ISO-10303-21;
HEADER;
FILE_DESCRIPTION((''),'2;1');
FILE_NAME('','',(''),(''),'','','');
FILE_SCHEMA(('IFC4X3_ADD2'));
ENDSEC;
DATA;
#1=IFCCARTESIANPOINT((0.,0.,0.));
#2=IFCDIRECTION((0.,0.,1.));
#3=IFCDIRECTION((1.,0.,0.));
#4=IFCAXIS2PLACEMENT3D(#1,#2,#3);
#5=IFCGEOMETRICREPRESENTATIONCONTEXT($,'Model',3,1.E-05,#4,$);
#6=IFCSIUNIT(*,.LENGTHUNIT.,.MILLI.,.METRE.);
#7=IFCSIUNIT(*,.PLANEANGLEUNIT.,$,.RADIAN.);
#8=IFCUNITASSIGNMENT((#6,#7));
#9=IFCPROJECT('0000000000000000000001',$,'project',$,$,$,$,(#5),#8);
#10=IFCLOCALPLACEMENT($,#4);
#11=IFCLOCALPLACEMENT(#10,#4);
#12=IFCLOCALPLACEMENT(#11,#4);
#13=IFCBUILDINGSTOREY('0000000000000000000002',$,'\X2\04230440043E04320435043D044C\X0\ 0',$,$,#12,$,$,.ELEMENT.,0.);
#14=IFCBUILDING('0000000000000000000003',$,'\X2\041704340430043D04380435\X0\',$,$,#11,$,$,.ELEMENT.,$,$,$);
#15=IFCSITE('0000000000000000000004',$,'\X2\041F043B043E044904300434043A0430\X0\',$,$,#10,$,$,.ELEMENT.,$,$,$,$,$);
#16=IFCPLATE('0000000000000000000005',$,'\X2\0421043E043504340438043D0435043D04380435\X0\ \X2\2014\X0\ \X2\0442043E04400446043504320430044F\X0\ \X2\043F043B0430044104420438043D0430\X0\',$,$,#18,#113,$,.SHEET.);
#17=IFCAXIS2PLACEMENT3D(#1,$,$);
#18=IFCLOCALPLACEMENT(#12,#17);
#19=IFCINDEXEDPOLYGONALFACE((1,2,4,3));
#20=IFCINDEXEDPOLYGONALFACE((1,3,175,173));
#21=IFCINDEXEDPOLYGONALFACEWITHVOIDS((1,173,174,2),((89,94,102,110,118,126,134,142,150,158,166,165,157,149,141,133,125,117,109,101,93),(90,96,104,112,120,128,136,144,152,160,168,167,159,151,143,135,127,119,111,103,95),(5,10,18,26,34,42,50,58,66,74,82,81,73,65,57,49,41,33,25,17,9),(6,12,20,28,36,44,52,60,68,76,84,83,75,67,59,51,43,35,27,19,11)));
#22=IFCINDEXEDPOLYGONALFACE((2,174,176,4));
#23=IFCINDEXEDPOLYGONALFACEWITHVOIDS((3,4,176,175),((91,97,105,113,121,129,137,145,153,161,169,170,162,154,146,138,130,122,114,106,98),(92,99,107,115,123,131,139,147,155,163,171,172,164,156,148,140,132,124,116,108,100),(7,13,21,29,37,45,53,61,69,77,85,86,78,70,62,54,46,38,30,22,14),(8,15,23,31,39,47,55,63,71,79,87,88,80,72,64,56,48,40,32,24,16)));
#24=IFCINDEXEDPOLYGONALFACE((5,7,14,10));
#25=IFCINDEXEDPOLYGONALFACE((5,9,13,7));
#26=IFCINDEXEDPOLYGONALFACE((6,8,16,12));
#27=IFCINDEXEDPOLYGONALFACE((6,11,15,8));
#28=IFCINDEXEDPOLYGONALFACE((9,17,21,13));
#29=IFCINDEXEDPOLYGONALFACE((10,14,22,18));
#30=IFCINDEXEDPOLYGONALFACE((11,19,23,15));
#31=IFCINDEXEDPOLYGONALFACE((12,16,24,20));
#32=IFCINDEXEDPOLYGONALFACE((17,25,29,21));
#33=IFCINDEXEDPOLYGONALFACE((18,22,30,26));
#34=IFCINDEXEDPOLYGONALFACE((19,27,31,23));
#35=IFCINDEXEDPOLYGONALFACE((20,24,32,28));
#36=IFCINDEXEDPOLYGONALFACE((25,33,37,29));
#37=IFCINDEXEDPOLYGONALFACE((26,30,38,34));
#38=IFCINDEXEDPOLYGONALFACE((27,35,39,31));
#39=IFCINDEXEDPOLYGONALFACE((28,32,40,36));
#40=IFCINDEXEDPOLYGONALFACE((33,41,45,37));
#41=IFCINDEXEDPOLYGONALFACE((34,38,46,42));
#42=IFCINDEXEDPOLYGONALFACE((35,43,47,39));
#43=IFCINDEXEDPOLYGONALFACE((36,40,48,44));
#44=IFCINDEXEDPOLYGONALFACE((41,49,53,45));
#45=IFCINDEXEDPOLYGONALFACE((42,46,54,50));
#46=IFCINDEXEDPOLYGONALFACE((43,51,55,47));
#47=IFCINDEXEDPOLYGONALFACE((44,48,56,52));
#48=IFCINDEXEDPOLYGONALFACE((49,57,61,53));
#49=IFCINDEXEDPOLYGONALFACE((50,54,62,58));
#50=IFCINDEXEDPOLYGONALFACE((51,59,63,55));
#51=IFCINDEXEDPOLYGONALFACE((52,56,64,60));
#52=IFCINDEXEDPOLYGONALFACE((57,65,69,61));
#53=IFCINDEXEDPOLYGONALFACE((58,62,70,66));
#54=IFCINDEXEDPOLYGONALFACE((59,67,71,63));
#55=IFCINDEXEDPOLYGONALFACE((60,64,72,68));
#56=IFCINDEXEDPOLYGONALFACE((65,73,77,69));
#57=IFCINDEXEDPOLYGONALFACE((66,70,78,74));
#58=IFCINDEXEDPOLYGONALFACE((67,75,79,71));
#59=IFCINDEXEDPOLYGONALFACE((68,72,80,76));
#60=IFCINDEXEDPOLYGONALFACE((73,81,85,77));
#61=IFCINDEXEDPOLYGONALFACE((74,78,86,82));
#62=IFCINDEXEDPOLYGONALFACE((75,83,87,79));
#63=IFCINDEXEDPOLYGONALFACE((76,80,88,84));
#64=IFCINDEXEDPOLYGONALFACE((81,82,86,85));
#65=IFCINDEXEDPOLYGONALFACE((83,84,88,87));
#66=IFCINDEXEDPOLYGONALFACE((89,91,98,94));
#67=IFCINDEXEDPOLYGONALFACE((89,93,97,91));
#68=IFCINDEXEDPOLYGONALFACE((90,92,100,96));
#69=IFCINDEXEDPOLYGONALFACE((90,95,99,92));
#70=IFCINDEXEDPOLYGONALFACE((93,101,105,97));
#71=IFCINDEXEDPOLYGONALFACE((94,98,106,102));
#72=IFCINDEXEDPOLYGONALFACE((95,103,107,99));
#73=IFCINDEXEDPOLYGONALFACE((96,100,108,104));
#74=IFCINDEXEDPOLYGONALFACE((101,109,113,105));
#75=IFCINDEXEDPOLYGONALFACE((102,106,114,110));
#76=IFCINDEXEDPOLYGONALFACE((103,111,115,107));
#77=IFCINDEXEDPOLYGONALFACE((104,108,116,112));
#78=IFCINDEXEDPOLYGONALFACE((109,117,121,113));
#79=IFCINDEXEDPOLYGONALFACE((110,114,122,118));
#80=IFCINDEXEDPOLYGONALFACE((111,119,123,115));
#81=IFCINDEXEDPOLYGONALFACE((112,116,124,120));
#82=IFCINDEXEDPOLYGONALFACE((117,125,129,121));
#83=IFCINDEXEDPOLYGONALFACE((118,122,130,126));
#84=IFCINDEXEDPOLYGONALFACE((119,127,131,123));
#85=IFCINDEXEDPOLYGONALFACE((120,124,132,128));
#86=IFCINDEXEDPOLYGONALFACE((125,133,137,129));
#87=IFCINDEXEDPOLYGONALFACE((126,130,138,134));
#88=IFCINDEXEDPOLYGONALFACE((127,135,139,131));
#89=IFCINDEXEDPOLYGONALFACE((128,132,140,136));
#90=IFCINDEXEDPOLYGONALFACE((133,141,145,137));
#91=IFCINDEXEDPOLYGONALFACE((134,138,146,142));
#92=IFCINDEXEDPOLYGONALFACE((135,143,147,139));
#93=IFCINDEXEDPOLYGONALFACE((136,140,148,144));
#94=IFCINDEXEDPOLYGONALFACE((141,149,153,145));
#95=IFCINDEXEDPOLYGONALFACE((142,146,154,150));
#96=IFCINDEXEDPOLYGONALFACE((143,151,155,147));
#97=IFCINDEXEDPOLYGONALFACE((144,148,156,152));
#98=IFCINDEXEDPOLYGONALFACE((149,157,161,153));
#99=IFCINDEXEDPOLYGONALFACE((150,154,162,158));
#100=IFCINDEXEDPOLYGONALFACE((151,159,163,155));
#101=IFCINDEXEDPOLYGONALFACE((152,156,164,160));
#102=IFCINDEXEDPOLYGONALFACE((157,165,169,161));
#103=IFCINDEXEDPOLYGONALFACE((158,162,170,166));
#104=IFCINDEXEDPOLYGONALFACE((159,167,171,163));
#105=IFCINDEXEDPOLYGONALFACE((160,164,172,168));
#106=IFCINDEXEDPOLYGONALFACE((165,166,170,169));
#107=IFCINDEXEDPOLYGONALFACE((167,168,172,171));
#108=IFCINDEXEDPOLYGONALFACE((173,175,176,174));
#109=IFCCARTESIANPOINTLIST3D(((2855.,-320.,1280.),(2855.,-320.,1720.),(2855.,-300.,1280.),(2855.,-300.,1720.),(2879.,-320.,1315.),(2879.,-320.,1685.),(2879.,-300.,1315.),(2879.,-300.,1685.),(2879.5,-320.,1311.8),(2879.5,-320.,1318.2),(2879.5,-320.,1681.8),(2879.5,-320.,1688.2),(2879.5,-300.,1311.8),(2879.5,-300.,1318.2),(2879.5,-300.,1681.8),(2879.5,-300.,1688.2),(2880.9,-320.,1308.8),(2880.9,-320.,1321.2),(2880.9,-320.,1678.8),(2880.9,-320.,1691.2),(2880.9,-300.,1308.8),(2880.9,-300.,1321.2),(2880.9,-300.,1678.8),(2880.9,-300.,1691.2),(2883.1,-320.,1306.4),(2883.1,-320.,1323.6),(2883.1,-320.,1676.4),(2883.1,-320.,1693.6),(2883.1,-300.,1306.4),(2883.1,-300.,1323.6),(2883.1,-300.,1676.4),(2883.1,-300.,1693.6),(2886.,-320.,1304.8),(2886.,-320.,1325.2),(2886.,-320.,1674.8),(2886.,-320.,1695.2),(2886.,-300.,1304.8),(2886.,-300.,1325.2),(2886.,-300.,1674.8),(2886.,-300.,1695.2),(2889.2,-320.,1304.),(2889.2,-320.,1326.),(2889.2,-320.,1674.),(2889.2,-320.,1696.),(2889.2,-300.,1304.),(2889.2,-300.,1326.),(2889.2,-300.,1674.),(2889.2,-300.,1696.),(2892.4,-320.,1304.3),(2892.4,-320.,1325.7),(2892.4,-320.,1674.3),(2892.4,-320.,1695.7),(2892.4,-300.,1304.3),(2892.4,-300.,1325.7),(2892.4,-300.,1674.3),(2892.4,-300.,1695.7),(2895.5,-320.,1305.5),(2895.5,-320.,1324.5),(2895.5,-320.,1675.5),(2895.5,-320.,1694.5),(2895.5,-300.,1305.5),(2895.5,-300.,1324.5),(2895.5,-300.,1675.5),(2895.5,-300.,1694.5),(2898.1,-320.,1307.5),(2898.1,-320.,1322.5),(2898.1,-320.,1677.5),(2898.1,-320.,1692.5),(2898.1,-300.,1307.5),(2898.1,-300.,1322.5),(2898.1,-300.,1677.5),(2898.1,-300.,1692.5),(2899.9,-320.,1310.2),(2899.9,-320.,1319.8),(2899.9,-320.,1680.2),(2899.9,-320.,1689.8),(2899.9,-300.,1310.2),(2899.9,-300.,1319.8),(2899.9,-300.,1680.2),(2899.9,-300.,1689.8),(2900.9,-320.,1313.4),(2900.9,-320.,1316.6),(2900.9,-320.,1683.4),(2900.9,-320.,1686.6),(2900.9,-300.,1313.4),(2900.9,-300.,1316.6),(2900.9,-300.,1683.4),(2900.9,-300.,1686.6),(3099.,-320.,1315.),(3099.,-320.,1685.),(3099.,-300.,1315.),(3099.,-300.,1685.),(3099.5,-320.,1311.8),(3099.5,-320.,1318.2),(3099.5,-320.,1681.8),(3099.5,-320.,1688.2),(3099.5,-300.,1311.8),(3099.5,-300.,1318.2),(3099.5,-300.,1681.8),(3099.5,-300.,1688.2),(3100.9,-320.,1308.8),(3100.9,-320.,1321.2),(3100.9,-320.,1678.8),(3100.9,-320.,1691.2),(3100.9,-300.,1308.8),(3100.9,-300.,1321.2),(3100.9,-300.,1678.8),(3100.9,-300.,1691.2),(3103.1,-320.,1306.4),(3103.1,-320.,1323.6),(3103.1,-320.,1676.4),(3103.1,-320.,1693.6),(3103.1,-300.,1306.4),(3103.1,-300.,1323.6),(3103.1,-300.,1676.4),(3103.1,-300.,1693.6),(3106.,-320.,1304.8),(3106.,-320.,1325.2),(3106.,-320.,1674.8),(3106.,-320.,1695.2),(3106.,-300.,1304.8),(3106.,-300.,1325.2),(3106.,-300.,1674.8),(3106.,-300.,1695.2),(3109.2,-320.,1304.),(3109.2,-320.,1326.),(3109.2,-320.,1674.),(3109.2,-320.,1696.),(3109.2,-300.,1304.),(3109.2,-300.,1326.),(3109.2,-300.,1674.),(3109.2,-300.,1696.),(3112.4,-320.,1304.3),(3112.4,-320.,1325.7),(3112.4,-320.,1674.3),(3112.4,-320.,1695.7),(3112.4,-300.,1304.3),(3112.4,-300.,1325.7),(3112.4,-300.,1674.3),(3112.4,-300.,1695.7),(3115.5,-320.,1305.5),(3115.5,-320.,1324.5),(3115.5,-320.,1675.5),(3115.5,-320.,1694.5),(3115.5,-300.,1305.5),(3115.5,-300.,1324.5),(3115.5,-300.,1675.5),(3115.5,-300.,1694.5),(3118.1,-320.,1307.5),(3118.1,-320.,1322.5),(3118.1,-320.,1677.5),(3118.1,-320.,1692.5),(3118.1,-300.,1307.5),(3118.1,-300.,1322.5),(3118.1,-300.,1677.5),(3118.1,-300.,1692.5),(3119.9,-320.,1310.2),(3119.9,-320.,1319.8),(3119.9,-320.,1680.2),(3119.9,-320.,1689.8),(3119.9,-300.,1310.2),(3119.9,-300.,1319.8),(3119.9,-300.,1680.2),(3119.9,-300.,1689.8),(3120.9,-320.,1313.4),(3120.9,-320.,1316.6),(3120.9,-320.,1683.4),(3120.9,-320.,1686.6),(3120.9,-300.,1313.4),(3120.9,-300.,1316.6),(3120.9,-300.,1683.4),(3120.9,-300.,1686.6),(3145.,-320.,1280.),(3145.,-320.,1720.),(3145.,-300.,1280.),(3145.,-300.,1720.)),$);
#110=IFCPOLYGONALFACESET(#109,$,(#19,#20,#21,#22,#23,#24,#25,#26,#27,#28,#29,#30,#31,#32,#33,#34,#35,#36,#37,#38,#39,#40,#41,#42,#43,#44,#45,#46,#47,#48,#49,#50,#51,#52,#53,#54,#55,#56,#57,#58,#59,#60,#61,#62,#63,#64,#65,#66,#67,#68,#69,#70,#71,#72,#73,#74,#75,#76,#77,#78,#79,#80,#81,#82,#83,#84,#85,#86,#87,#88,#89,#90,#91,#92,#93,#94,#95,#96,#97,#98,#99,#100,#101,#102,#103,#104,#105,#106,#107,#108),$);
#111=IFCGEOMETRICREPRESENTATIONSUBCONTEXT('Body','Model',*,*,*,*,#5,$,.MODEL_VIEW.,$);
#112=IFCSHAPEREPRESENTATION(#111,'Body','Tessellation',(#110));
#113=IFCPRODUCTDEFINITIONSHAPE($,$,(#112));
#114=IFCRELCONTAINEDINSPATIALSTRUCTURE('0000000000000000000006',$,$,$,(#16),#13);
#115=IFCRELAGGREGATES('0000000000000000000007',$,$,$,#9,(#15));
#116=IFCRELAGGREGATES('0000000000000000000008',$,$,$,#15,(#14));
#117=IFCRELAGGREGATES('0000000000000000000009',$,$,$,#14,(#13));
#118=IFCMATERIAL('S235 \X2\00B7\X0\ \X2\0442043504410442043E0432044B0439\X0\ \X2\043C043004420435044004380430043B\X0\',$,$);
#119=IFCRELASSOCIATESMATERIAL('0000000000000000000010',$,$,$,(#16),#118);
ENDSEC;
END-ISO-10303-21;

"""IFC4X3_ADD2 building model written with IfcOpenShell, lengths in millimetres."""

from ifc_helpers import new_model, si_unit, frame, origin_with_axes, place, context, subcontext, project, spatial, polyline, circle, outline, extrude, material, element, save


model = new_model("IFC4X3_ADD2")

# Units and contexts
model_context = context("Model", 3, precision=1e-05, world=origin_with_axes())
body_context = subcontext(model_context, "Body", "Model", "MODEL_VIEW")
ifc_project = project(units=[si_unit("LENGTHUNIT", "METRE", prefix="MILLI"), si_unit("PLANEANGLEUNIT", "RADIAN")], contexts=[model_context])

# Site, building, storey
site_placement = place(None, origin_with_axes())
site = spatial("IfcSite", under=ifc_project, at=site_placement, Name="Площадка", CompositionType="ELEMENT")
building_placement = place(site_placement, origin_with_axes())
building = spatial("IfcBuilding", under=site, at=building_placement, Name="Здание", CompositionType="ELEMENT")
storey_placement = place(building_placement, origin_with_axes())
storey = spatial("IfcBuildingStorey", under=building, at=storey_placement, Name="Уровень 0", CompositionType="ELEMENT", Elevation=0.0)

# Shared definitions
ifc_material = material(Name="S235 · тестовый материал")

# Plate, openings
plate_1_placement = place(storey_placement, frame((3145.0, -320.0, 1280.0), z_axis=(0.0, 1.0, 0.0), x_axis=(-1.0, 0.0, 0.0)))
plate_1 = element("IfcPlate", 1, at=plate_1_placement, inside=storey, material=ifc_material, Name="Соединение — торцевая пластина", PredefinedType="SHEET", context=body_context, shape_type="SweptSolid", body=[
    extrude(outline(polyline([(0.0, 0.0), (290.0, 0.0), (290.0, 440.0), (0.0, 440.0), (0.0, 0.0)])), origin_with_axes(), (0.0, 0.0, 1.0), 20.0),
])
opening_1_placement = place(plate_1_placement, frame((35.0, 35.0, -1.0), z_axis=(0.0, 0.0, 1.0), x_axis=(1.0, 0.0, 0.0)))
element("IfcOpeningElement", 2, at=opening_1_placement, cuts=plate_1, PredefinedType="OPENING", context=body_context, shape_type="SweptSolid", body=[
    extrude(circle(Radius=11.0), origin_with_axes(), (0.0, 0.0, 1.0), 42.0),
])
opening_2_placement = place(plate_1_placement, frame((35.0, 405.0, -1.0), z_axis=(0.0, 0.0, 1.0), x_axis=(1.0, 0.0, 0.0)))
element("IfcOpeningElement", 3, at=opening_2_placement, cuts=plate_1, PredefinedType="OPENING", context=body_context, shape_type="SweptSolid", body=[
    extrude(circle(Radius=11.0), origin_with_axes(), (0.0, 0.0, 1.0), 42.0),
])
opening_3_placement = place(plate_1_placement, frame((255.0, 35.0, -1.0), z_axis=(0.0, 0.0, 1.0), x_axis=(1.0, 0.0, 0.0)))
element("IfcOpeningElement", 4, at=opening_3_placement, cuts=plate_1, PredefinedType="OPENING", context=body_context, shape_type="SweptSolid", body=[
    extrude(circle(Radius=11.0), origin_with_axes(), (0.0, 0.0, 1.0), 42.0),
])
opening_4_placement = place(plate_1_placement, frame((255.0, 405.0, -1.0), z_axis=(0.0, 0.0, 1.0), x_axis=(1.0, 0.0, 0.0)))
element("IfcOpeningElement", 5, at=opening_4_placement, cuts=plate_1, PredefinedType="OPENING", context=body_context, shape_type="SweptSolid", body=[
    extrude(circle(Radius=11.0), origin_with_axes(), (0.0, 0.0, 1.0), 42.0),
])

save(model, "model.ifc")
